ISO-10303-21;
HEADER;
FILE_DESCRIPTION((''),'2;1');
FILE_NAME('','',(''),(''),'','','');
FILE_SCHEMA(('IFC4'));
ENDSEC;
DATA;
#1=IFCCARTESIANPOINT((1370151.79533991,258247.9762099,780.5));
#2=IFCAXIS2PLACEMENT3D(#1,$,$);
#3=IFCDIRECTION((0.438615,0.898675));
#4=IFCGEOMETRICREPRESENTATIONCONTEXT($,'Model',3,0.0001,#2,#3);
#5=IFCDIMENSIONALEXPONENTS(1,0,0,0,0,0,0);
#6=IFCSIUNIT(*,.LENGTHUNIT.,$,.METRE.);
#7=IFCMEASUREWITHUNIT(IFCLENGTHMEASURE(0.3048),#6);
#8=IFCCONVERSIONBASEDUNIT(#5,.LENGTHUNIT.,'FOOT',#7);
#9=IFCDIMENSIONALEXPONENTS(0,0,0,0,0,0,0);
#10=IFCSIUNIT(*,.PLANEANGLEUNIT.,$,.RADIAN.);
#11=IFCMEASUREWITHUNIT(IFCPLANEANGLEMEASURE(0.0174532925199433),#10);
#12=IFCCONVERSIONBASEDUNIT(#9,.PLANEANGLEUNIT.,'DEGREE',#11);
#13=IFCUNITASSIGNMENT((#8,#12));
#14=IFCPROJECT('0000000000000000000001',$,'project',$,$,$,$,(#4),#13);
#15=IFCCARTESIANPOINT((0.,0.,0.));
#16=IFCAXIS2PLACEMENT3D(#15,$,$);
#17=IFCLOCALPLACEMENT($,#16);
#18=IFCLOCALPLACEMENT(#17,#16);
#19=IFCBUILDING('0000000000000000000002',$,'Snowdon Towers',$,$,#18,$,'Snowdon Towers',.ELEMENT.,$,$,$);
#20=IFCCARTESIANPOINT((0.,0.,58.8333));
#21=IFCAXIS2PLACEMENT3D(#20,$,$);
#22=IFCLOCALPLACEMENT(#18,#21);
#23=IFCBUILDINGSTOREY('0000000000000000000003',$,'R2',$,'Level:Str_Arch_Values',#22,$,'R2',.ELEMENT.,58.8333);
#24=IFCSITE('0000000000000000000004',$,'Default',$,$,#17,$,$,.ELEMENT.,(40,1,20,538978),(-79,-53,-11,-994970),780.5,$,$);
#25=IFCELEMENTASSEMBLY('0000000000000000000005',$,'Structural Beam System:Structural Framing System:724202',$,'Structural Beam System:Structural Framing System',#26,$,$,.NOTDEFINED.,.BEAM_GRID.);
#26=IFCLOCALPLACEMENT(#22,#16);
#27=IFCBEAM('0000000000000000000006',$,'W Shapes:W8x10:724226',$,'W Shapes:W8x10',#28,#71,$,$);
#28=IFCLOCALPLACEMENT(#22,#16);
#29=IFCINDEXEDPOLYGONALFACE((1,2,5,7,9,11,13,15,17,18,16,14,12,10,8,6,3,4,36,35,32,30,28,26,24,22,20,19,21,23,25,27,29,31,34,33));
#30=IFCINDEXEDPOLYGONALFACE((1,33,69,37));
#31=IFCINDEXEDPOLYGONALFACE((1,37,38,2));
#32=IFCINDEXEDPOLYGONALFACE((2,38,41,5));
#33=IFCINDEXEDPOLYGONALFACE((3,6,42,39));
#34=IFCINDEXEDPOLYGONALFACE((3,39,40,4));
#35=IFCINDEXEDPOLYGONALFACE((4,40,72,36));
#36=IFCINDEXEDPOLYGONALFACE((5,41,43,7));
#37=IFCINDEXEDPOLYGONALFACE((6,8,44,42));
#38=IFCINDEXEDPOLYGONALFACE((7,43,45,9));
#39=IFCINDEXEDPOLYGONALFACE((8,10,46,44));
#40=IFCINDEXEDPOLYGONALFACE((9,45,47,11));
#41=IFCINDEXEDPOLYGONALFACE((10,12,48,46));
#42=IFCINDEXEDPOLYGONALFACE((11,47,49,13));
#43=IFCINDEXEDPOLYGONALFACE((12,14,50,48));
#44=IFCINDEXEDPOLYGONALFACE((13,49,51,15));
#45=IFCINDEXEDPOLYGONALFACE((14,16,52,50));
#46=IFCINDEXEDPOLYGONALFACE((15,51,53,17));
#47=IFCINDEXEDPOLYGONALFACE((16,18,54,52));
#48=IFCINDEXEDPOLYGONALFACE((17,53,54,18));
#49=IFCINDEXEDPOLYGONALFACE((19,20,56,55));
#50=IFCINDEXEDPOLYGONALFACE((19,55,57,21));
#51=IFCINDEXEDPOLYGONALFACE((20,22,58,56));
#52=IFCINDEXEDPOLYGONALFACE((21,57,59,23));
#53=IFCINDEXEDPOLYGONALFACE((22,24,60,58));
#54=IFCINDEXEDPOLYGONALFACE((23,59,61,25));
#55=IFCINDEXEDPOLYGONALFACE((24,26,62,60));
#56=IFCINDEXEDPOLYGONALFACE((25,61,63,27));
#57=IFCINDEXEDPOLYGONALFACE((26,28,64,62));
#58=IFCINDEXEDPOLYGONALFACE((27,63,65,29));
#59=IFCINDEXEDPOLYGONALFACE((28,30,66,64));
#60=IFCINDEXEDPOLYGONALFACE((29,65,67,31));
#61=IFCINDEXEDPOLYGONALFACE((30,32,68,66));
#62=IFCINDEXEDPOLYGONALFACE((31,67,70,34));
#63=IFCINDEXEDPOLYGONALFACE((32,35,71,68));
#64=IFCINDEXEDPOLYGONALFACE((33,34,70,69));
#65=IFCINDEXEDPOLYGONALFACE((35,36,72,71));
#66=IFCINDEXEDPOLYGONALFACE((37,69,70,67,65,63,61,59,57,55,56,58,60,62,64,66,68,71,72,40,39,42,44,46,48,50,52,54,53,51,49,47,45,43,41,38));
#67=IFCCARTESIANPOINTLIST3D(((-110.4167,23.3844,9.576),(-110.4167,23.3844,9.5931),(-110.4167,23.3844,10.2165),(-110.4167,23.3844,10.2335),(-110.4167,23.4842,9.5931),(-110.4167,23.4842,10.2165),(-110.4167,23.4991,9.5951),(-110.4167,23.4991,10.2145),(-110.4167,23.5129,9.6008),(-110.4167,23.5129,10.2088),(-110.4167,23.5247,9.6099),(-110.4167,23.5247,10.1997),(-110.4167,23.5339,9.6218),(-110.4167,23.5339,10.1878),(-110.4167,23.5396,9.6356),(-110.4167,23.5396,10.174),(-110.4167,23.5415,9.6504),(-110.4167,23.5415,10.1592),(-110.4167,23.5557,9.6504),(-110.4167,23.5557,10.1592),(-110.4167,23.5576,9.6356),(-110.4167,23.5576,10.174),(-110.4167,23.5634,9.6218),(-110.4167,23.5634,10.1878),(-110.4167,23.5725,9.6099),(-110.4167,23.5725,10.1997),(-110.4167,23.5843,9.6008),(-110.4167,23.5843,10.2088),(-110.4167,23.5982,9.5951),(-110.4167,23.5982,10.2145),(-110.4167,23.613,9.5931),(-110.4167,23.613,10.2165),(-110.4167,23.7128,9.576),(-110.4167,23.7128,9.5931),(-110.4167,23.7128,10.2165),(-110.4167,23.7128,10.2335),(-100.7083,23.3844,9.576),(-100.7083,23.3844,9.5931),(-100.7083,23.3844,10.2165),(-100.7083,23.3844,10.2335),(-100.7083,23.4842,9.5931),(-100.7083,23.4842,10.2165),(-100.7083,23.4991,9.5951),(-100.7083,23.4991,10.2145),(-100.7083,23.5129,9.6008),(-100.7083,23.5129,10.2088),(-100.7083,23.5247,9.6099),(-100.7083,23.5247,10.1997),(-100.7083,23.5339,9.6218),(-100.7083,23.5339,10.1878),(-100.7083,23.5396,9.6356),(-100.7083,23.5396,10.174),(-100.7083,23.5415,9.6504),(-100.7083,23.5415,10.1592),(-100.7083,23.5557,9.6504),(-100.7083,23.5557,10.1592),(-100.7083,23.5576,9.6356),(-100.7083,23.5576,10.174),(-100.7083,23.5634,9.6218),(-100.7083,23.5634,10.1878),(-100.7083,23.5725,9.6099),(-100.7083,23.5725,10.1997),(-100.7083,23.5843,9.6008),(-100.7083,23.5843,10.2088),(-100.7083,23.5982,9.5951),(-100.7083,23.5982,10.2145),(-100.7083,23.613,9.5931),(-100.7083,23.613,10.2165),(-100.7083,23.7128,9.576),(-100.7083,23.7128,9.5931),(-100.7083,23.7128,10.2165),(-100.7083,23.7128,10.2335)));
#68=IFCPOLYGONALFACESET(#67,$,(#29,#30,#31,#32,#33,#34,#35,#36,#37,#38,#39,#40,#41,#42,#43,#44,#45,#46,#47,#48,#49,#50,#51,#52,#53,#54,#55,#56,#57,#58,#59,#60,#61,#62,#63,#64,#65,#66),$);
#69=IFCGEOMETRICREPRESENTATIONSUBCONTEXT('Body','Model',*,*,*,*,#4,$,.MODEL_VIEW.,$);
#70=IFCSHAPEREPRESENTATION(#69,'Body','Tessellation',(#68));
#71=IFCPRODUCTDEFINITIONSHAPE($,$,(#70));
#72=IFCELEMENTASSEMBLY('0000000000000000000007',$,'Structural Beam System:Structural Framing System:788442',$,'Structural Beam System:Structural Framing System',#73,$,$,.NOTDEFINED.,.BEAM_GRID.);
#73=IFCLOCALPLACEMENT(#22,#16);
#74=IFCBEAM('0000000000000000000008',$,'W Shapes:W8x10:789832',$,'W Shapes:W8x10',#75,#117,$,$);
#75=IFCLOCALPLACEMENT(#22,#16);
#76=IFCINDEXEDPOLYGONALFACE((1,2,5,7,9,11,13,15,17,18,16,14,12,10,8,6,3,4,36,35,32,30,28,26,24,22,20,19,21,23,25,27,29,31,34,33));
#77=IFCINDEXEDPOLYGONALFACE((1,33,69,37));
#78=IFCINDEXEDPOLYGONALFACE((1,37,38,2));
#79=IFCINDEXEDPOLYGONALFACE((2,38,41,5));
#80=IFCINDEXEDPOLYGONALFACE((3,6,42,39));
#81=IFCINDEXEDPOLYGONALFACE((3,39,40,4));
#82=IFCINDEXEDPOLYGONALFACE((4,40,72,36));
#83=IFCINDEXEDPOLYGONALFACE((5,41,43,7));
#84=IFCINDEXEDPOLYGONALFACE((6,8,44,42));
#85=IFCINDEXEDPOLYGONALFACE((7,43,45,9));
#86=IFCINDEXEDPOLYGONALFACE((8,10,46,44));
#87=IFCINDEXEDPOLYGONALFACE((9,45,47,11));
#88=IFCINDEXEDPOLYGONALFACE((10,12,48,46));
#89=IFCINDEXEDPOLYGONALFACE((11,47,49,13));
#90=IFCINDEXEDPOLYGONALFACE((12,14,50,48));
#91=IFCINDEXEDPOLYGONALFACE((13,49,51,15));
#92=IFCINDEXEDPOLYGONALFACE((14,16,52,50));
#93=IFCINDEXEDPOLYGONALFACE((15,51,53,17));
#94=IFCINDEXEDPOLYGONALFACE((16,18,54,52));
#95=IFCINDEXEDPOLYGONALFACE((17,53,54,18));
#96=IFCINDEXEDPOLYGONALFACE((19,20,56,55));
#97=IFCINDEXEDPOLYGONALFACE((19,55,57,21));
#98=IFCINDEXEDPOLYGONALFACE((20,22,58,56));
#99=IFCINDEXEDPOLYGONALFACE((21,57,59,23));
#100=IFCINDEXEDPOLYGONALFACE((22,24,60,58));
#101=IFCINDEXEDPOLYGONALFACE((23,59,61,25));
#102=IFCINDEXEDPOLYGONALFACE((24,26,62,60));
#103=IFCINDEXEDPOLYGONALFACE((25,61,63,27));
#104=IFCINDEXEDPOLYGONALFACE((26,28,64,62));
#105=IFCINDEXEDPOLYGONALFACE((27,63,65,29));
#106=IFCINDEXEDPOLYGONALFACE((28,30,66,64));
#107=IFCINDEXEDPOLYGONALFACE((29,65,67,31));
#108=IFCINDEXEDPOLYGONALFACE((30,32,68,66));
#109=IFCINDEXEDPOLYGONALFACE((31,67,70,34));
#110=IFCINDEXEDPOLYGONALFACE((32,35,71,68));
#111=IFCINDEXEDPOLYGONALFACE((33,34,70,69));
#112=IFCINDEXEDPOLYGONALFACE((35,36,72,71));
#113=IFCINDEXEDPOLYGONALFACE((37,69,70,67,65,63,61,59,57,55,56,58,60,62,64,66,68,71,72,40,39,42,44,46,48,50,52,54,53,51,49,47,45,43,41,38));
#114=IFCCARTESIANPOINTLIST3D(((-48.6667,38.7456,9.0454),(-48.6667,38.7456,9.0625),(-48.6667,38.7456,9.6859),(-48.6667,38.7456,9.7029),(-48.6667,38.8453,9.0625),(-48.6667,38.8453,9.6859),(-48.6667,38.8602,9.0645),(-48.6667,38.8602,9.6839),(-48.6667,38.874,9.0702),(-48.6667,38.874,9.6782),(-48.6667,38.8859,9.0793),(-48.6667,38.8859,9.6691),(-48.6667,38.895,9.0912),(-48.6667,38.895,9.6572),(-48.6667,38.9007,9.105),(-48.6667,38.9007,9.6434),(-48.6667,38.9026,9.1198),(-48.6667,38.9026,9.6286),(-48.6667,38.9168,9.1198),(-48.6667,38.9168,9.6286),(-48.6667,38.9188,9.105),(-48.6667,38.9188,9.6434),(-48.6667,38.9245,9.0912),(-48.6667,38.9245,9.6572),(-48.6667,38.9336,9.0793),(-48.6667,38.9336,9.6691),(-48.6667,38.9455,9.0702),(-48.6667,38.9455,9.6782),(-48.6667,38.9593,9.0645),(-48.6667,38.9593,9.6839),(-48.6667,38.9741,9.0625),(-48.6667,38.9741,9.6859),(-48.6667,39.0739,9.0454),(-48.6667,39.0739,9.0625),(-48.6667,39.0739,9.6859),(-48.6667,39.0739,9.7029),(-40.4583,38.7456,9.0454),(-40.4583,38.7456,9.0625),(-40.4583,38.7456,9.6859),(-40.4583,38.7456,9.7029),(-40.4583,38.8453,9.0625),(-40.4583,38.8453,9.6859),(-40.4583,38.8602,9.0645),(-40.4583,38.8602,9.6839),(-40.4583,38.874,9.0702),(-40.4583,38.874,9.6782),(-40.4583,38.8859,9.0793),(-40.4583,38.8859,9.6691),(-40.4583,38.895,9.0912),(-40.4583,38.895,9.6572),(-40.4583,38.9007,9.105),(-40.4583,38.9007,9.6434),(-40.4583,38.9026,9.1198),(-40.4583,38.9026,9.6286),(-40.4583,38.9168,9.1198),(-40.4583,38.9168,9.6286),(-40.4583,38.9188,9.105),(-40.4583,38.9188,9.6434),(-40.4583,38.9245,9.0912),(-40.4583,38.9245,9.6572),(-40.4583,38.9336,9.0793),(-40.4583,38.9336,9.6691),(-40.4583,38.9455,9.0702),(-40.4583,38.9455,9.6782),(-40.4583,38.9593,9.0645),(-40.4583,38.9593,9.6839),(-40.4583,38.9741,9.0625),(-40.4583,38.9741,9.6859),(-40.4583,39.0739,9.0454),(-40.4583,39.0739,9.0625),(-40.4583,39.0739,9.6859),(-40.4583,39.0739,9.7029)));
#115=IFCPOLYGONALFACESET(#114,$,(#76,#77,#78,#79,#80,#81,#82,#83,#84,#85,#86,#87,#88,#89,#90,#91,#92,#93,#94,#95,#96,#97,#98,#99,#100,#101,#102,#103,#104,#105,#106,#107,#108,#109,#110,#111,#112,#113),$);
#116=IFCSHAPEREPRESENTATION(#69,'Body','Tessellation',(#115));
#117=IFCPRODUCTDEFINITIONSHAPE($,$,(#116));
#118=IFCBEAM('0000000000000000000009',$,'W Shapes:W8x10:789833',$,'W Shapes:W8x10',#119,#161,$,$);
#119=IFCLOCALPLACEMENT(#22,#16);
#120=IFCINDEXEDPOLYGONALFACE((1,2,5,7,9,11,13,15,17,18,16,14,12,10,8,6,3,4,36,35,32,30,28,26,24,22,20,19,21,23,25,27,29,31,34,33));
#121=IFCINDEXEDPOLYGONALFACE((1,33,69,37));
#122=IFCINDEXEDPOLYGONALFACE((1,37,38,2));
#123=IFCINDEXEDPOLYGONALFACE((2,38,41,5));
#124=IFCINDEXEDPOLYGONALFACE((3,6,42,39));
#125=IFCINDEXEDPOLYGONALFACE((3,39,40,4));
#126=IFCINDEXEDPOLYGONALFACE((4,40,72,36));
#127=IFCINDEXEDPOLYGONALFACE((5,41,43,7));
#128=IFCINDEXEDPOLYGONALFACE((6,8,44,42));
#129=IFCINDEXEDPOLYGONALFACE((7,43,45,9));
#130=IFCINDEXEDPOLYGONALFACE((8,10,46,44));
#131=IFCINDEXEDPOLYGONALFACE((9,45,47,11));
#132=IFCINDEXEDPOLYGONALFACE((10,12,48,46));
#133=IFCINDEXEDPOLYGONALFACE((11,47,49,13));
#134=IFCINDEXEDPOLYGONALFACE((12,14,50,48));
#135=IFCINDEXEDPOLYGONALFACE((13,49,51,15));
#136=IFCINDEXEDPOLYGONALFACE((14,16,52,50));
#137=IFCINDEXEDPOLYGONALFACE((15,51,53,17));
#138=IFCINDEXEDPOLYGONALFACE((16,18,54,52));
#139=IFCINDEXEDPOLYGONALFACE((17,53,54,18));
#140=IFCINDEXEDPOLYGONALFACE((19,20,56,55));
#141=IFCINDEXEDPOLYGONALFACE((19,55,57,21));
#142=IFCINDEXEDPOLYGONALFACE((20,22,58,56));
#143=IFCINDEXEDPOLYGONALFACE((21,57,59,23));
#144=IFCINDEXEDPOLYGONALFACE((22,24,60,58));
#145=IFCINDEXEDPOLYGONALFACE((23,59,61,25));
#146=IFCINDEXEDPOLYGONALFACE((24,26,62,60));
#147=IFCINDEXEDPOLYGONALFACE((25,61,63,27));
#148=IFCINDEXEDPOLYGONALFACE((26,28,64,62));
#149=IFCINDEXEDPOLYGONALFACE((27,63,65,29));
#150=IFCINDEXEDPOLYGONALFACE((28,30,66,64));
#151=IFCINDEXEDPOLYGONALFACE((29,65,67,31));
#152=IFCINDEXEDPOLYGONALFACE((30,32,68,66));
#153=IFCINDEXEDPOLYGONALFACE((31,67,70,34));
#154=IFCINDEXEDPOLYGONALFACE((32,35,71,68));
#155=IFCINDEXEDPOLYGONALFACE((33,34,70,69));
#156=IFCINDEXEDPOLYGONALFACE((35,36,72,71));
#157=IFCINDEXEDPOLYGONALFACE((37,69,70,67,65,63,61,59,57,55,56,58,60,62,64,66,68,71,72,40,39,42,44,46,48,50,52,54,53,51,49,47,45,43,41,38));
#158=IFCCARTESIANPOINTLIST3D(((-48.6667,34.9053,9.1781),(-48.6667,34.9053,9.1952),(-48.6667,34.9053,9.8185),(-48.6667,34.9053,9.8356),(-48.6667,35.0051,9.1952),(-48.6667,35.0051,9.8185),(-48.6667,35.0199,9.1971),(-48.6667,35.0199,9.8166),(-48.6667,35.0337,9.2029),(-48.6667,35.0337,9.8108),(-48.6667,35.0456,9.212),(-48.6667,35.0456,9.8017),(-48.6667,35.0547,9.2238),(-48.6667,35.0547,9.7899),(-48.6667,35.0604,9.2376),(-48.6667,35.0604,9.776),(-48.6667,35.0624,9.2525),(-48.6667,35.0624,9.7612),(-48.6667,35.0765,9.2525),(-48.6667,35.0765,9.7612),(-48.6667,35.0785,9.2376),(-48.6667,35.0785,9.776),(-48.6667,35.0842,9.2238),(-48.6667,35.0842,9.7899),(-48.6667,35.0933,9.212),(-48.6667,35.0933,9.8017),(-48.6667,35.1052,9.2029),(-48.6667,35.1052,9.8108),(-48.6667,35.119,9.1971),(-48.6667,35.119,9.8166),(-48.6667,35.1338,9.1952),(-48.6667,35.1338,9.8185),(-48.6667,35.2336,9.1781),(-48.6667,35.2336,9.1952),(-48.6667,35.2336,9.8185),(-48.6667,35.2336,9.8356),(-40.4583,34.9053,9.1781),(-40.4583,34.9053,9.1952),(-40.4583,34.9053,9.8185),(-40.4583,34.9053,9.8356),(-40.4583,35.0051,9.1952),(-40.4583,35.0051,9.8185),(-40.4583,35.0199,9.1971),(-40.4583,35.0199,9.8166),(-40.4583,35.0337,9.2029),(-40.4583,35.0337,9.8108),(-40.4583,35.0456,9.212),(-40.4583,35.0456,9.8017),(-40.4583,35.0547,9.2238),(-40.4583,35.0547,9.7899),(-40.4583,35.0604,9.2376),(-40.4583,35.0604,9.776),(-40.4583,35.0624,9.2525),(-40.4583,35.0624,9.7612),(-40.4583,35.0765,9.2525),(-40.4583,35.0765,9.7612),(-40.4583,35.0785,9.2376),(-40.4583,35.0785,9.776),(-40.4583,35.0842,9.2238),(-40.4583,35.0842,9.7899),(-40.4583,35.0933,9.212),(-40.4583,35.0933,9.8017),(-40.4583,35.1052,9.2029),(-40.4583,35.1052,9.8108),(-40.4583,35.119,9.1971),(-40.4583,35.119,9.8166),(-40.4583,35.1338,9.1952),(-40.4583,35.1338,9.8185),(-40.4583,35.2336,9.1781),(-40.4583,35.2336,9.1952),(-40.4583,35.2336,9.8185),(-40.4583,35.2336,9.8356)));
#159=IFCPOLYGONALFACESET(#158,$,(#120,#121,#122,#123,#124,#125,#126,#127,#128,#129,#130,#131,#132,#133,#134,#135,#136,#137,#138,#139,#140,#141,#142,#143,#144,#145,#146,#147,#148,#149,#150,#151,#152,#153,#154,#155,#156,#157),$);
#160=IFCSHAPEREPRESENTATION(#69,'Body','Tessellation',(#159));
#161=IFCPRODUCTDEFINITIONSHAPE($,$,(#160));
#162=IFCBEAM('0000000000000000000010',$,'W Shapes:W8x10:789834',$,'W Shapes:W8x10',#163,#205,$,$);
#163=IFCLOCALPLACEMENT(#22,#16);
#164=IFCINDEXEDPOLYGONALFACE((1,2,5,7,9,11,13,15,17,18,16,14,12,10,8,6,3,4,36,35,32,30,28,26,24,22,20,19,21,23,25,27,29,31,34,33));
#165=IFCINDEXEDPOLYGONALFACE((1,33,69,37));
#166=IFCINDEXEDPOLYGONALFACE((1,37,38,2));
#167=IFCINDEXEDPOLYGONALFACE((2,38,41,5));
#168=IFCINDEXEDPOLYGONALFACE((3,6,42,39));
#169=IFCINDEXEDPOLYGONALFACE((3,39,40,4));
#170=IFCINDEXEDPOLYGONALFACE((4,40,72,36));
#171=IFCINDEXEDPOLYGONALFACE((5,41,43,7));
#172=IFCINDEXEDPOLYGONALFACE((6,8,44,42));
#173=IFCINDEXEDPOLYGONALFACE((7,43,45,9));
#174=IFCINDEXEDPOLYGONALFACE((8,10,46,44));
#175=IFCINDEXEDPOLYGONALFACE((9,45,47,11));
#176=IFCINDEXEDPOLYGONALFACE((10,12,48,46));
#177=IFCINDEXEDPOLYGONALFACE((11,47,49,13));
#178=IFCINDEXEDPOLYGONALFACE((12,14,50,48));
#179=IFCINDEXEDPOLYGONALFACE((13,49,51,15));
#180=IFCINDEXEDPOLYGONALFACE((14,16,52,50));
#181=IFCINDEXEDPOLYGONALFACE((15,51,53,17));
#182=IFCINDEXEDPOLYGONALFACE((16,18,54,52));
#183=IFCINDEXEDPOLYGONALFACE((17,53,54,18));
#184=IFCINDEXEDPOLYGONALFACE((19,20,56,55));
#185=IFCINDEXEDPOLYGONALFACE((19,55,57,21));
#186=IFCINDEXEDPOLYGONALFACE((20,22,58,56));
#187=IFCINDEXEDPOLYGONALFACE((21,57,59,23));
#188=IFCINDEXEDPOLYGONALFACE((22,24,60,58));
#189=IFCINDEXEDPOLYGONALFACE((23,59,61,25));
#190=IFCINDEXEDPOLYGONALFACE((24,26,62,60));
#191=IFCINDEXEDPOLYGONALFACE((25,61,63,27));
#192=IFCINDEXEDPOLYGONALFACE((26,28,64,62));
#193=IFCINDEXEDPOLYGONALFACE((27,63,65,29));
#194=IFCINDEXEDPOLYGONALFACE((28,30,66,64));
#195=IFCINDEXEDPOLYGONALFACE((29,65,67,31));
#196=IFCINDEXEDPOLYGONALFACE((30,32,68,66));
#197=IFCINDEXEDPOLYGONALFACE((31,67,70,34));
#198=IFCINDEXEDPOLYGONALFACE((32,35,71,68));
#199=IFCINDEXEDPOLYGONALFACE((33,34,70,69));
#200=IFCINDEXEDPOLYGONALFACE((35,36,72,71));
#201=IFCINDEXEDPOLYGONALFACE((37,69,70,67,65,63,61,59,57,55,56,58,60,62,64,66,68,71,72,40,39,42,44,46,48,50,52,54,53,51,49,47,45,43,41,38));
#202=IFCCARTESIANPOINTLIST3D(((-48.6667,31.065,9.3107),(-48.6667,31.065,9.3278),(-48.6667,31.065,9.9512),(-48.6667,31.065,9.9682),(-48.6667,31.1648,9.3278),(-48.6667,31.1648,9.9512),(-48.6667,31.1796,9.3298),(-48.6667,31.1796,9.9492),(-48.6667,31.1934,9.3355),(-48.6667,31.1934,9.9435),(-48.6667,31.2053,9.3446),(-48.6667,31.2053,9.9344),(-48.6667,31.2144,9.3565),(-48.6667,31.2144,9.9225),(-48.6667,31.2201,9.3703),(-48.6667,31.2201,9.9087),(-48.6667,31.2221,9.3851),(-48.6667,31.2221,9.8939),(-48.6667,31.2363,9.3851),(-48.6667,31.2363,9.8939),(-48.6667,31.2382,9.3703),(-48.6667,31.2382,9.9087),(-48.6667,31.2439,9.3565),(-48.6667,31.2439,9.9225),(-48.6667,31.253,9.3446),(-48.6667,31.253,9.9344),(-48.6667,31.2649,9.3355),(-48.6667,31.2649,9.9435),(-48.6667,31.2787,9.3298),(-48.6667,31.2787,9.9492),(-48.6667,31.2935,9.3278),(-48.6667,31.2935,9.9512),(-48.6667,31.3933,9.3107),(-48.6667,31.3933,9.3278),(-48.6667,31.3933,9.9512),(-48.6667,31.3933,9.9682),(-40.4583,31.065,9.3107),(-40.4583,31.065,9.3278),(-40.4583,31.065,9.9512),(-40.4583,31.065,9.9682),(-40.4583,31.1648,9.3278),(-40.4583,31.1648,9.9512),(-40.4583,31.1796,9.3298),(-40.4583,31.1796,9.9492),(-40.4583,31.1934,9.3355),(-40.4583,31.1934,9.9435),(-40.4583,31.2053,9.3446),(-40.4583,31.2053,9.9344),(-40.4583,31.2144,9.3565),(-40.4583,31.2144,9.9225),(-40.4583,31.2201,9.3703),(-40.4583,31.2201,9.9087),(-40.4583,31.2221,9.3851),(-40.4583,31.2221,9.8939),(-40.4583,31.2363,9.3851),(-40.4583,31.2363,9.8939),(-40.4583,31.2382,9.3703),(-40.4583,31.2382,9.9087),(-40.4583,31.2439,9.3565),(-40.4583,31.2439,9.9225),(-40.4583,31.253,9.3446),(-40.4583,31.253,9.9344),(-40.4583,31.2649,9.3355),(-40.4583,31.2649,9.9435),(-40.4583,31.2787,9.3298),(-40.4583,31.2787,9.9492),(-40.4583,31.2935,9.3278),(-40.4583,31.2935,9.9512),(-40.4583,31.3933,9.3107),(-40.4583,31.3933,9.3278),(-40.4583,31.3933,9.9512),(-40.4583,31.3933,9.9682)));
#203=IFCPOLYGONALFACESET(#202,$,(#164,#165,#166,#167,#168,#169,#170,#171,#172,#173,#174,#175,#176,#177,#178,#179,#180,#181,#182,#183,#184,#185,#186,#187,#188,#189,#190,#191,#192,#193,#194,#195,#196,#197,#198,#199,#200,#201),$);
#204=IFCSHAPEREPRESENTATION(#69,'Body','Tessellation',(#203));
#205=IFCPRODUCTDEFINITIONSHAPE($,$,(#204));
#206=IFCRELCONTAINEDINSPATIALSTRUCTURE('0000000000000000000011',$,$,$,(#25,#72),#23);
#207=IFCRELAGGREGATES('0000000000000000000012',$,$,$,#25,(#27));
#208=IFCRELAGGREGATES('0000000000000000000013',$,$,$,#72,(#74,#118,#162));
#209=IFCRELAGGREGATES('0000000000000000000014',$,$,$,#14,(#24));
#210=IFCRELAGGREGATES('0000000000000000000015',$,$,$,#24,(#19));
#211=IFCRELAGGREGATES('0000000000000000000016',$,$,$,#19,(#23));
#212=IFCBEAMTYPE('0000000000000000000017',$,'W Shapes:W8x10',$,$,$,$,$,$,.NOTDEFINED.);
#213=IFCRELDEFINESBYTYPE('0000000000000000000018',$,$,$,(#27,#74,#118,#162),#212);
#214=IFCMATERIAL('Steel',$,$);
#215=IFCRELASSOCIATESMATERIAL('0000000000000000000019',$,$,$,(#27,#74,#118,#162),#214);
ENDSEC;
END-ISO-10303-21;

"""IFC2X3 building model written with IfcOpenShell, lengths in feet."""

from ifc_helpers import new_model, entity, si_unit, converted_unit, direction, frame, frame_2d, origin, place, context, subcontext, project, spatial, i_section, extrude, material, type_object, element, aggregate, save


model = new_model("IFC2X3")

# Units and contexts
model_context = context("Model", 3, precision=0.0001, world=frame((1370151.79533991, 258247.9762099, 780.5)), true_north=direction((0.438615, 0.898675)))
body_context = subcontext(model_context, "Body", "Model", "MODEL_VIEW")
ifc_project = project(units=[converted_unit("LENGTHUNIT", "FOOT", entity("IfcLengthMeasure", 0.3048), si_unit("LENGTHUNIT", "METRE"), dimensions=[1, 0, 0, 0, 0, 0, 0]), converted_unit("PLANEANGLEUNIT", "DEGREE", entity("IfcPlaneAngleMeasure", 0.0174532925199433), si_unit("PLANEANGLEUNIT", "RADIAN"), dimensions=[0, 0, 0, 0, 0, 0, 0])], contexts=[model_context])

# Site, building, storey
site_placement = place(None, origin())
site = spatial("IfcSite", under=ifc_project, at=site_placement, Name="Default", CompositionType="ELEMENT", RefLatitude=(40, 1, 20, 538978), RefLongitude=(-79, -53, -11, -994970), RefElevation=780.5)
building_placement = place(site_placement, origin())
building = spatial("IfcBuilding", under=site, at=building_placement, Name="Snowdon Towers", LongName="Snowdon Towers", CompositionType="ELEMENT")
storey_placement = place(building_placement, frame((0.0, 0.0, 58.8333)))
storey = spatial("IfcBuildingStorey", under=building, at=storey_placement, Name="R2", ObjectType="Level:Str_Arch_Values", LongName="R2", CompositionType="ELEMENT", Elevation=58.8333)

# Element assemblies, beams
assembly_1_placement = place(storey_placement, origin())
assembly_1 = element("IfcElementAssembly", 1, at=assembly_1_placement, inside=storey, Name="Structural Beam System:Structural Framing System:724202", ObjectType="Structural Beam System:Structural Framing System", AssemblyPlace="NOTDEFINED", PredefinedType="BEAM_GRID")
ifc_material_1 = material(Name="Steel")
beam_type = type_object("IfcBeamType", Name="W Shapes:W8x10", PredefinedType="NOTDEFINED")
beam_1_placement = place(assembly_1_placement, frame((-110.5, 23.5486, 10.2335)))
beam_1 = element("IfcBeam", 2, at=beam_1_placement, type_object=beam_type, material=ifc_material_1, Name="W Shapes:W8x10:724226", ObjectType="W Shapes:W8x10", context=body_context, shape_type="SweptSolid", body=[
    extrude(i_section(OverallWidth=0.3283, OverallDepth=0.6575, WebThickness=0.0142, FlangeThickness=0.0171, FilletRadius=0.0573, at=frame_2d((0.0, 0.0), x_axis=(0.0, 1.0))), frame((0.0833, 0.0, -0.3288), z_axis=(1.0, 0.0, 0.0), x_axis=(0.0, 0.0, -1.0)), (0.0, 0.0, 1.0), 9.7083),
])
aggregate(assembly_1, [beam_1])
assembly_2_placement = place(storey_placement, origin())
assembly_2 = element("IfcElementAssembly", 3, at=assembly_2_placement, inside=storey, Name="Structural Beam System:Structural Framing System:788442", ObjectType="Structural Beam System:Structural Framing System", AssemblyPlace="NOTDEFINED", PredefinedType="BEAM_GRID")
beam_2_placement = place(assembly_2_placement, frame((-48.75, 38.9097, 9.7029)))
beam_2 = element("IfcBeam", 4, at=beam_2_placement, type_object=beam_type, material=ifc_material_1, Name="W Shapes:W8x10:789832", ObjectType="W Shapes:W8x10", context=body_context, shape_type="SweptSolid", body=[
    extrude(i_section(OverallWidth=0.3283, OverallDepth=0.6575, WebThickness=0.0142, FlangeThickness=0.0171, FilletRadius=0.0573, at=frame_2d((0.0, 0.0), x_axis=(0.0, 1.0))), frame((0.0833, 0.0, -0.3288), z_axis=(1.0, 0.0, 0.0), x_axis=(0.0, 0.0, -1.0)), (0.0, 0.0, 1.0), 8.2083),
])
beam_3_placement = place(assembly_2_placement, frame((-48.75, 35.0694, 9.8356)))
beam_3 = element("IfcBeam", 5, at=beam_3_placement, type_object=beam_type, material=ifc_material_1, Name="W Shapes:W8x10:789833", ObjectType="W Shapes:W8x10", context=body_context, shape_type="SweptSolid", body=[
    extrude(i_section(OverallWidth=0.3283, OverallDepth=0.6575, WebThickness=0.0142, FlangeThickness=0.0171, FilletRadius=0.0573, at=frame_2d((0.0, 0.0), x_axis=(0.0, 1.0))), frame((0.0833, 0.0, -0.3288), z_axis=(1.0, 0.0, 0.0), x_axis=(0.0, 0.0, -1.0)), (0.0, 0.0, 1.0), 8.2083),
])
beam_4_placement = place(assembly_2_placement, frame((-48.75, 31.2292, 9.9682)))
beam_4 = element("IfcBeam", 6, at=beam_4_placement, type_object=beam_type, material=ifc_material_1, Name="W Shapes:W8x10:789834", ObjectType="W Shapes:W8x10", context=body_context, shape_type="SweptSolid", body=[
    extrude(i_section(OverallWidth=0.3283, OverallDepth=0.6575, WebThickness=0.0142, FlangeThickness=0.0171, FilletRadius=0.0573, at=frame_2d((0.0, 0.0), x_axis=(0.0, 1.0))), frame((0.0833, 0.0, -0.3288), z_axis=(1.0, 0.0, 0.0), x_axis=(0.0, 0.0, -1.0)), (0.0, 0.0, 1.0), 8.2083),
])
aggregate(assembly_2, [beam_2, beam_3, beam_4])

save(model, "model.ifc")
